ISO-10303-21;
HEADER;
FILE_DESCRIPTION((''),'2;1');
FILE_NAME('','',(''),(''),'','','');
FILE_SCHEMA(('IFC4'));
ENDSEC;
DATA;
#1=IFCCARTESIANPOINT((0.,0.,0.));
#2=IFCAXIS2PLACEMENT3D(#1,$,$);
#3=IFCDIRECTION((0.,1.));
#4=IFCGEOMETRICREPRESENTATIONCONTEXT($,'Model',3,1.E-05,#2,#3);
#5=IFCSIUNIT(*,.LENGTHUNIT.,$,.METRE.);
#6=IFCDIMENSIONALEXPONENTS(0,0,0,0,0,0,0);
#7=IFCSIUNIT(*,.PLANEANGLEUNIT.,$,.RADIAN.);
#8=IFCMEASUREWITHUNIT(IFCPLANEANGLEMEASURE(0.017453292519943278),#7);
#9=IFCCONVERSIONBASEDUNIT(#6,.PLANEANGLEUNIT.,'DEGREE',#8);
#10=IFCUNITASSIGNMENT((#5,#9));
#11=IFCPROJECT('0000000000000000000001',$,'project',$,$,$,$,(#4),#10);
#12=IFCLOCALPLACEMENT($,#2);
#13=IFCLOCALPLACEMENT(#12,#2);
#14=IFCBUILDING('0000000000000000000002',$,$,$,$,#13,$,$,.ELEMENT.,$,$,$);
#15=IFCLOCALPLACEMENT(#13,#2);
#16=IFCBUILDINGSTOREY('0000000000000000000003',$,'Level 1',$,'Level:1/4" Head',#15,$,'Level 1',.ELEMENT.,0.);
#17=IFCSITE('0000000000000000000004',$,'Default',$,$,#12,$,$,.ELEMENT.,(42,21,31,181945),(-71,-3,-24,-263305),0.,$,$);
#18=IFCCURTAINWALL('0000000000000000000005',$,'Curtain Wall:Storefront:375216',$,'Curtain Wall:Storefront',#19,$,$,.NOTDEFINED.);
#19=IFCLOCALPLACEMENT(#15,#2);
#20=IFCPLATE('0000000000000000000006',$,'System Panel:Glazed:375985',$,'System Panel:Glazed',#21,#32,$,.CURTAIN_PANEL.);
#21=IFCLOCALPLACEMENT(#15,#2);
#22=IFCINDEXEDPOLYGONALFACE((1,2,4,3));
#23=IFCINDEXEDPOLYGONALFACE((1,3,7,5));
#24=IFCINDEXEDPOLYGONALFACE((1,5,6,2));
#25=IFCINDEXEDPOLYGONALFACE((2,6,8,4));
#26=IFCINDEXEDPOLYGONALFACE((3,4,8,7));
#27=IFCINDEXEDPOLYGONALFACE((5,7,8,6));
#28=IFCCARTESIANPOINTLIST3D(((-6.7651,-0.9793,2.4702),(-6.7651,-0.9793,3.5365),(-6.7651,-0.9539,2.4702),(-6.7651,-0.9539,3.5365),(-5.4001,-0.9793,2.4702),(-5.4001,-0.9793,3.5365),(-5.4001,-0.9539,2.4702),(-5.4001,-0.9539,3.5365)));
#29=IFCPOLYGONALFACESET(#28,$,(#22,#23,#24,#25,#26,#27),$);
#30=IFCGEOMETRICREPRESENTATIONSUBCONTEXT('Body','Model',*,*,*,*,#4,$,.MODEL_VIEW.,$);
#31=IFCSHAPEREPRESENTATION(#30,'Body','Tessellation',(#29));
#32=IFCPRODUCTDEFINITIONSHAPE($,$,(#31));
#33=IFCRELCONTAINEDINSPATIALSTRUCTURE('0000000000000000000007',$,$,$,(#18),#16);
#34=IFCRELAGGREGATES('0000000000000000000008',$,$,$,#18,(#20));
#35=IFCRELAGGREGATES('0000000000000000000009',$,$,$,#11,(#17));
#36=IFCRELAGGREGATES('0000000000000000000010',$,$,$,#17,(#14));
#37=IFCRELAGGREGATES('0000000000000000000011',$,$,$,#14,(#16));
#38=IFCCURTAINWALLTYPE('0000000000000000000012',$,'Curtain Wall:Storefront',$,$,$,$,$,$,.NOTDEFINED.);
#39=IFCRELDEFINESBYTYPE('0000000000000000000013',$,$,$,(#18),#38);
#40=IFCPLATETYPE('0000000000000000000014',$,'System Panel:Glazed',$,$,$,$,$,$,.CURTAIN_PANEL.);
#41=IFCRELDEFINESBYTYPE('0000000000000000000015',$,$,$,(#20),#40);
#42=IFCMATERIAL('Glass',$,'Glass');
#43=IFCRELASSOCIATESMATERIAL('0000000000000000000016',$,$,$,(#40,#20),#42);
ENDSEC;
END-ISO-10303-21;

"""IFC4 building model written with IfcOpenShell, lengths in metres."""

from ifc_helpers import new_model, entity, si_unit, converted_unit, direction, frame, frame_2d, origin, place, context, subcontext, project, spatial, rectangle, extrude, source, transform, mapped, material, type_object, type_shapes, element, aggregate, save


model = new_model("IFC4")

# Units and contexts
model_context = context("Model", 3, precision=1e-05, world=origin(), true_north=direction((0.0, 1.0)))
body_context = subcontext(model_context, "Body", "Model", "MODEL_VIEW")
ifc_project = project(units=[si_unit("LENGTHUNIT", "METRE"), converted_unit("PLANEANGLEUNIT", "DEGREE", entity("IfcPlaneAngleMeasure", 0.017453292519943278), si_unit("PLANEANGLEUNIT", "RADIAN"), dimensions=[0, 0, 0, 0, 0, 0, 0])], contexts=[model_context])

# Site, building, storey
site_placement = place(None, origin())
site = spatial("IfcSite", under=ifc_project, at=site_placement, Name="Default", CompositionType="ELEMENT", RefLatitude=(42, 21, 31, 181945), RefLongitude=(-71, -3, -24, -263305), RefElevation=0.0)
building_placement = place(site_placement, origin())
building = spatial("IfcBuilding", under=site, at=building_placement, CompositionType="ELEMENT")
storey_placement = place(building_placement, origin())
storey = spatial("IfcBuildingStorey", under=building, at=storey_placement, Name="Level 1", ObjectType="Level:1/4\" Head", LongName="Level 1", CompositionType="ELEMENT", Elevation=0.0)

# Curtain wall, plate
curtain_wall_type = type_object("IfcCurtainWallType", Name="Curtain Wall:Storefront", PredefinedType="NOTDEFINED")
curtain_wall_placement = place(storey_placement, origin())
curtain_wall = element("IfcCurtainWall", 1, at=curtain_wall_placement, inside=storey, type_object=curtain_wall_type, Name="Curtain Wall:Storefront:375216", ObjectType="Curtain Wall:Storefront", PredefinedType="NOTDEFINED")
ifc_material_1 = material(Name="Glass", Category="Glass")
plate_type_1 = type_object("IfcPlateType", Name="System Panel:Glazed", PredefinedType="CURTAIN_PANEL", material=ifc_material_1)
shared_shape_1 = source(origin(), body_context, "Body", "SweptSolid", [
    extrude(rectangle(XDim=0.0254, YDim=1.3651, at=frame_2d((0.0, 0.0), x_axis=(1.0, 0.0))), frame((0.6825, 0.0127, 0.0), z_axis=(0.0, 0.0, 1.0), x_axis=(0.0, 1.0, 0.0)), (0.0, 0.0, 1.0), 1.0663),
])
type_shapes(plate_type_1, [shared_shape_1])
plate_1_placement = place(curtain_wall_placement, frame((-6.7651, -0.9793, 2.4701)))
plate_1 = element("IfcPlate", 2, at=plate_1_placement, type_object=plate_type_1, material=ifc_material_1, Name="System Panel:Glazed:375985", ObjectType="System Panel:Glazed", PredefinedType="CURTAIN_PANEL", context=body_context, shape_type="MappedRepresentation", body=[
    mapped(shared_shape_1, transform((0.0, 0.0, 0.0), scale=1.0)),
])
aggregate(curtain_wall, [plate_1])

save(model, "model.ifc")
